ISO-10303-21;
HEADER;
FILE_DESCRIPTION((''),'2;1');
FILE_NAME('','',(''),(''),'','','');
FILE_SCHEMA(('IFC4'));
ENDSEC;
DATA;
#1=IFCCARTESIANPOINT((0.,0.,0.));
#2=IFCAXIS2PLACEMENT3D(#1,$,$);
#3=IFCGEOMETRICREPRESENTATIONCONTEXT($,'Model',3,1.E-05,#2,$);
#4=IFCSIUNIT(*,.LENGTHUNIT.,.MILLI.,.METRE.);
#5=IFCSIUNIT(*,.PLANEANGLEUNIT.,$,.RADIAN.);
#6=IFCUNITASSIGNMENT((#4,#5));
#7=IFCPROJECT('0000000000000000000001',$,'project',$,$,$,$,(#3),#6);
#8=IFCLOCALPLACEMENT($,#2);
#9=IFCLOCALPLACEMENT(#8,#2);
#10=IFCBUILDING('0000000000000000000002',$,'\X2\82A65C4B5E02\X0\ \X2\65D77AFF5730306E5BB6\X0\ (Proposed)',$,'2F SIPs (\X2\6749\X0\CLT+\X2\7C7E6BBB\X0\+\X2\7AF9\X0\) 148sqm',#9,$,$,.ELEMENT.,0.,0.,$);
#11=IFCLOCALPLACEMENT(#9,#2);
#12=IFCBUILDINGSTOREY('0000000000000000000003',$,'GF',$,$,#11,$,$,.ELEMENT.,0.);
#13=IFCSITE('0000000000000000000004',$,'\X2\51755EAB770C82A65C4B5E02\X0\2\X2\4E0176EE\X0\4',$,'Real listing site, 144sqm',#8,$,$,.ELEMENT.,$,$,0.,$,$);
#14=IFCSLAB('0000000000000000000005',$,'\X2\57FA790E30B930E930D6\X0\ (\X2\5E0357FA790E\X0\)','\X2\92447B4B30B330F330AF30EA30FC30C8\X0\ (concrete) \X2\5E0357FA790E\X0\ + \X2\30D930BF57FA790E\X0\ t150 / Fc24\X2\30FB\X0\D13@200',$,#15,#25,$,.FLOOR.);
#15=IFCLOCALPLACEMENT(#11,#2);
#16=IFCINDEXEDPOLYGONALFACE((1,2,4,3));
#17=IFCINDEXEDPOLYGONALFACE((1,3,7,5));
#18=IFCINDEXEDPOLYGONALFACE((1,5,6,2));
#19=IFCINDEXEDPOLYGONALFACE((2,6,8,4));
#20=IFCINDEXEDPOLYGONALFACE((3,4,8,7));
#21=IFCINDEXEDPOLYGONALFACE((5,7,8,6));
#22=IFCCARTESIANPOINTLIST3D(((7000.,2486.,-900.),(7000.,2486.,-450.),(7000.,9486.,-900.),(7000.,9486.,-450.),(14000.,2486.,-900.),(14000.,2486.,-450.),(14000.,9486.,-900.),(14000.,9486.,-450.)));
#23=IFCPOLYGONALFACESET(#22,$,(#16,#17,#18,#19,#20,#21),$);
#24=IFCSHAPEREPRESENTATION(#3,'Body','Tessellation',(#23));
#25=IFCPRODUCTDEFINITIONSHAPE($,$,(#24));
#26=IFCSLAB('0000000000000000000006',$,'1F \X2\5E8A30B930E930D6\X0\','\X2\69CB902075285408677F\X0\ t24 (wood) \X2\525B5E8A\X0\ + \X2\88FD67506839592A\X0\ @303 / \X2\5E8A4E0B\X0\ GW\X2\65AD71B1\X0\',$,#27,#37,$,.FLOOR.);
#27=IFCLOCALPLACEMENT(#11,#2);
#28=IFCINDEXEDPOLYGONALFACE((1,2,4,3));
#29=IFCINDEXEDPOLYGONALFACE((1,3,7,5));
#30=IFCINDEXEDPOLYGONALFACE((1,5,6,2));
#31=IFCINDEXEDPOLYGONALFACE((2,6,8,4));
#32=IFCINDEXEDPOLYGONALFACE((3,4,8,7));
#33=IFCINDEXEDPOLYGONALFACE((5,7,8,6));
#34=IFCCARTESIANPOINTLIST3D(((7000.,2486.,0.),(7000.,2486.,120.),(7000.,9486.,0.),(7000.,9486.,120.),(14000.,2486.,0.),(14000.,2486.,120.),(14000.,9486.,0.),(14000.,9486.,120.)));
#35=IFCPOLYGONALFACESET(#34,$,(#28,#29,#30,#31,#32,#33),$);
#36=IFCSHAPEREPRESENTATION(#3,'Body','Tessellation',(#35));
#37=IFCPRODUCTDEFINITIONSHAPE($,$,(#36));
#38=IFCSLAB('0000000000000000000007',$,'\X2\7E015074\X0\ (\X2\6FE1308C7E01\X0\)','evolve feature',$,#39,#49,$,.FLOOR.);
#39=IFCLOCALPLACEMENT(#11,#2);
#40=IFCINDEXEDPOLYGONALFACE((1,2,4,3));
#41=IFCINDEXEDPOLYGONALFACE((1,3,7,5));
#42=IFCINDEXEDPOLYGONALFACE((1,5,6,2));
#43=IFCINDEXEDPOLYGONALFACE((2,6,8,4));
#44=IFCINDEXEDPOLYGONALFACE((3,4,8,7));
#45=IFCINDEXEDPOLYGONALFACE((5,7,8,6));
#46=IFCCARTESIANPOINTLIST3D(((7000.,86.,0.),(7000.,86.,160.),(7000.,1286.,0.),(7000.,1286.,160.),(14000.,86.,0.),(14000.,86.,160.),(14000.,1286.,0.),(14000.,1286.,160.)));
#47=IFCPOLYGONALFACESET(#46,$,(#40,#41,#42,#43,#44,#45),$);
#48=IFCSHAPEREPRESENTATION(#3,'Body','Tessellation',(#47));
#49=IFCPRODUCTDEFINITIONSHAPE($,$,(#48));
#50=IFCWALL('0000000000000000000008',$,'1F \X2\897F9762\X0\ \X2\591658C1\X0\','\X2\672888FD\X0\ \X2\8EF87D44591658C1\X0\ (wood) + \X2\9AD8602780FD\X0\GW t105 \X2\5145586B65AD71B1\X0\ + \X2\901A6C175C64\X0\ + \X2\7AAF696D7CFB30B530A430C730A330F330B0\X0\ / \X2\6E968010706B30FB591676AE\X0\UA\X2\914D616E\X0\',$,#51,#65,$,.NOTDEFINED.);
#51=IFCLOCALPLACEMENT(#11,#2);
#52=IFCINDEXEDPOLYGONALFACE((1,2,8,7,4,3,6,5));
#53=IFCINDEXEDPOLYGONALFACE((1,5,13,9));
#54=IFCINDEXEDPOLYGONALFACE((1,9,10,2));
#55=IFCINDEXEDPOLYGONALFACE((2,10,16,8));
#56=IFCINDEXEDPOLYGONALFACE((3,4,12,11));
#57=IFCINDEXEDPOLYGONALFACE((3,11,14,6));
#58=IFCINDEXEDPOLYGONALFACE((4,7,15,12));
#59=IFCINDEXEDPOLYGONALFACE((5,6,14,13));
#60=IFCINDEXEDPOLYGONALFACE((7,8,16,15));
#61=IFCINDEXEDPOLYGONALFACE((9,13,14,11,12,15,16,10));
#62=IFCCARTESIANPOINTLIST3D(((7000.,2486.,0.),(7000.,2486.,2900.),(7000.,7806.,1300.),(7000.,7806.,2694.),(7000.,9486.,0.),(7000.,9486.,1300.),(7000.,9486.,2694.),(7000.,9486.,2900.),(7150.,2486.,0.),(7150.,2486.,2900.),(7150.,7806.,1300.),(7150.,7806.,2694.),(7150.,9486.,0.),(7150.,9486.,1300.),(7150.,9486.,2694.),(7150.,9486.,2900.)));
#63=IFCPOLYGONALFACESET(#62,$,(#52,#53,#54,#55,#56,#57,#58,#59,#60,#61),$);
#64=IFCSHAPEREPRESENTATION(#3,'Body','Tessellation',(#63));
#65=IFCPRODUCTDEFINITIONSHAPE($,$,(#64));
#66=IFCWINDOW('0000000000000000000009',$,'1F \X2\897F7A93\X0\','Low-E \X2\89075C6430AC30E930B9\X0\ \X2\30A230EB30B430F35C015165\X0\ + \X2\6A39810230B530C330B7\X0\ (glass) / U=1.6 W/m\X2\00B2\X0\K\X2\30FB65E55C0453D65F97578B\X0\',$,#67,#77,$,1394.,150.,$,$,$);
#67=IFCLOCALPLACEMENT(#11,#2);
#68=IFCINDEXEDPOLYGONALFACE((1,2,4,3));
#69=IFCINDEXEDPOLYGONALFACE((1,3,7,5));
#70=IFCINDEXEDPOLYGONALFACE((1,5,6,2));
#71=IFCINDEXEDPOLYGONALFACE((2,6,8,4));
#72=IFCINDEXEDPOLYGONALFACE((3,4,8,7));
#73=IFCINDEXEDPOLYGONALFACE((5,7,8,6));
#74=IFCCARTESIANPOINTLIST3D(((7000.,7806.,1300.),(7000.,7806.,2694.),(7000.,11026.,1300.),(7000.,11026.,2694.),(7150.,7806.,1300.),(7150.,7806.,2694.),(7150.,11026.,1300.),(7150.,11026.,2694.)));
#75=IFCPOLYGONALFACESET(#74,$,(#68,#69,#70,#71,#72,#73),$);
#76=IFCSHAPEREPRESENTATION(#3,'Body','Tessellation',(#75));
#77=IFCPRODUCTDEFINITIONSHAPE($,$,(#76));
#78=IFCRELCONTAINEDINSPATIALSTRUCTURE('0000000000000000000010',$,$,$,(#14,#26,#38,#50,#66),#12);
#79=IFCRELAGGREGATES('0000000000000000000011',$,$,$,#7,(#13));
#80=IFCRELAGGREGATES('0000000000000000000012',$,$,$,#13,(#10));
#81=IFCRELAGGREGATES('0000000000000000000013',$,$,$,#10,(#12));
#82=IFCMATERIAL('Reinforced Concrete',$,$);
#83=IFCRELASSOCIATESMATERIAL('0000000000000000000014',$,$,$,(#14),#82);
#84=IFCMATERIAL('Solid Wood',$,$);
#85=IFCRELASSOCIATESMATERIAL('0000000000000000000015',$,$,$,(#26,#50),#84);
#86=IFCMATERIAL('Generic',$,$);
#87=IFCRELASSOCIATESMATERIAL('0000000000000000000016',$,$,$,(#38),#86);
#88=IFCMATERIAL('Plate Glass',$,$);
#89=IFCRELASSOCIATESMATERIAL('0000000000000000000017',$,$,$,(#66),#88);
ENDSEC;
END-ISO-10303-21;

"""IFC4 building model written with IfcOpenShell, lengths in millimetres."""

from ifc_helpers import new_model, si_unit, frame, frame_2d, origin, place, context, project, spatial, rectangle, extrude, material, element, fill, save


model = new_model("IFC4")

# Units and contexts
model_context = context("Model", 3, precision=1e-05, world=origin())
ifc_project = project(units=[si_unit("LENGTHUNIT", "METRE", prefix="MILLI"), si_unit("PLANEANGLEUNIT", "RADIAN")], contexts=[model_context])

# Site, building, storey
site_placement = place(None, origin())
site = spatial("IfcSite", under=ifc_project, at=site_placement, Name="兵庫県芦屋市2丁目4", ObjectType="Real listing site, 144sqm", CompositionType="ELEMENT", RefElevation=0.0)
building_placement = place(site_placement, origin())
building = spatial("IfcBuilding", under=site, at=building_placement, Name="芦屋市 旗竿地の家 (Proposed)", ObjectType="2F SIPs (杉CLT+籾殻+竹) 148sqm", CompositionType="ELEMENT", ElevationOfRefHeight=0.0, ElevationOfTerrain=0.0)
storey_placement = place(building_placement, origin())
storey = spatial("IfcBuildingStorey", under=building, at=storey_placement, Name="GF", CompositionType="ELEMENT", Elevation=0.0)

# Slabs
ifc_material_1 = material(Name="Reinforced Concrete")
slab_1_placement = place(storey_placement, frame((3500.0, 1243.0, -450.0)))
element("IfcSlab", 1, at=slab_1_placement, inside=storey, material=ifc_material_1, Name="基礎スラブ (布基礎)", Description="鉄筋コンクリート (concrete) 布基礎 + ベタ基礎 t150 / Fc24・D13@200", PredefinedType="FLOOR", context=model_context, shape_type="SweptSolid", body=[
    extrude(rectangle(XDim=7000.0, YDim=7000.0, at=frame_2d((3500.0, 3500.0))), frame((3500.0, 1243.0, -450.0)), (0.0, 0.0, 1.0), 450.0),
])
ifc_material_2 = material(Name="Solid Wood")
slab_2_placement = place(storey_placement, frame((3500.0, 1243.0, 0.0)))
element("IfcSlab", 2, at=slab_2_placement, inside=storey, material=ifc_material_2, Name="1F 床スラブ", Description="構造用合板 t24 (wood) 剛床 + 製材根太 @303 / 床下 GW断熱", PredefinedType="FLOOR", context=model_context, shape_type="SweptSolid", body=[
    extrude(rectangle(XDim=7000.0, YDim=7000.0, at=frame_2d((3500.0, 3500.0))), frame((3500.0, 1243.0, 0.0)), (0.0, 0.0, 1.0), 120.0),
])
ifc_material_3 = material(Name="Generic")
slab_3_placement = place(storey_placement, frame((3500.0, 43.0, 0.0)))
element("IfcSlab", 3, at=slab_3_placement, inside=storey, material=ifc_material_3, Name="縁側 (濡れ縁)", Description="evolve feature", PredefinedType="FLOOR", context=model_context, shape_type="SweptSolid", body=[
    extrude(rectangle(XDim=7000.0, YDim=1200.0, at=frame_2d((3500.0, 600.0))), frame((3500.0, 43.0, 0.0)), (0.0, 0.0, 1.0), 160.0),
])

# Shared definitions
ifc_material_4 = material(Name="Plate Glass")

# Wall, opening, window
wall_1_placement = place(storey_placement, frame((3500.0, 1243.0, 0.0)))
wall_1 = element("IfcWall", 4, at=wall_1_placement, inside=storey, material=ifc_material_2, Name="1F 西面 外壁", Description="木製 軸組外壁 (wood) + 高性能GW t105 充填断熱 + 通気層 + 窯業系サイディング / 準耐火・外皮UA配慮", PredefinedType="NOTDEFINED", context=model_context, shape_type="SweptSolid", body=[
    extrude(rectangle(XDim=150.0, YDim=7000.0, at=frame_2d((75.0, 3500.0))), frame((3500.0, 1243.0, 0.0)), (0.0, 0.0, 1.0), 2900.0),
])
opening_1_placement = place(storey_placement, frame((3500.0, 3903.0, 650.0)))
opening_1 = element("IfcOpeningElement", 5, at=opening_1_placement, cuts=wall_1, PredefinedType="NOTDEFINED", context=model_context, shape_type="SweptSolid", body=[
    extrude(rectangle(XDim=150.0, YDim=3220.0, at=frame_2d((75.0, 1610.0))), frame((3500.0, 3903.0, 650.0)), (0.0, 0.0, 1.0), 1394.0),
])
window_1_placement = place(storey_placement, frame((3500.0, 3903.0, 650.0)))
window_1 = element("IfcWindow", 6, at=window_1_placement, inside=storey, material=ifc_material_4, Name="1F 西窓", Description="Low-E 複層ガラス アルゴン封入 + 樹脂サッシ (glass) / U=1.6 W/m²K・日射取得型", OverallHeight=1394.0, OverallWidth=150.0, context=model_context, shape_type="SweptSolid", body=[
    extrude(rectangle(XDim=150.0, YDim=3220.0, at=frame_2d((75.0, 1610.0))), frame((3500.0, 3903.0, 650.0)), (0.0, 0.0, 1.0), 1394.0),
])
fill(opening_1, window_1)

save(model, "model.ifc")
